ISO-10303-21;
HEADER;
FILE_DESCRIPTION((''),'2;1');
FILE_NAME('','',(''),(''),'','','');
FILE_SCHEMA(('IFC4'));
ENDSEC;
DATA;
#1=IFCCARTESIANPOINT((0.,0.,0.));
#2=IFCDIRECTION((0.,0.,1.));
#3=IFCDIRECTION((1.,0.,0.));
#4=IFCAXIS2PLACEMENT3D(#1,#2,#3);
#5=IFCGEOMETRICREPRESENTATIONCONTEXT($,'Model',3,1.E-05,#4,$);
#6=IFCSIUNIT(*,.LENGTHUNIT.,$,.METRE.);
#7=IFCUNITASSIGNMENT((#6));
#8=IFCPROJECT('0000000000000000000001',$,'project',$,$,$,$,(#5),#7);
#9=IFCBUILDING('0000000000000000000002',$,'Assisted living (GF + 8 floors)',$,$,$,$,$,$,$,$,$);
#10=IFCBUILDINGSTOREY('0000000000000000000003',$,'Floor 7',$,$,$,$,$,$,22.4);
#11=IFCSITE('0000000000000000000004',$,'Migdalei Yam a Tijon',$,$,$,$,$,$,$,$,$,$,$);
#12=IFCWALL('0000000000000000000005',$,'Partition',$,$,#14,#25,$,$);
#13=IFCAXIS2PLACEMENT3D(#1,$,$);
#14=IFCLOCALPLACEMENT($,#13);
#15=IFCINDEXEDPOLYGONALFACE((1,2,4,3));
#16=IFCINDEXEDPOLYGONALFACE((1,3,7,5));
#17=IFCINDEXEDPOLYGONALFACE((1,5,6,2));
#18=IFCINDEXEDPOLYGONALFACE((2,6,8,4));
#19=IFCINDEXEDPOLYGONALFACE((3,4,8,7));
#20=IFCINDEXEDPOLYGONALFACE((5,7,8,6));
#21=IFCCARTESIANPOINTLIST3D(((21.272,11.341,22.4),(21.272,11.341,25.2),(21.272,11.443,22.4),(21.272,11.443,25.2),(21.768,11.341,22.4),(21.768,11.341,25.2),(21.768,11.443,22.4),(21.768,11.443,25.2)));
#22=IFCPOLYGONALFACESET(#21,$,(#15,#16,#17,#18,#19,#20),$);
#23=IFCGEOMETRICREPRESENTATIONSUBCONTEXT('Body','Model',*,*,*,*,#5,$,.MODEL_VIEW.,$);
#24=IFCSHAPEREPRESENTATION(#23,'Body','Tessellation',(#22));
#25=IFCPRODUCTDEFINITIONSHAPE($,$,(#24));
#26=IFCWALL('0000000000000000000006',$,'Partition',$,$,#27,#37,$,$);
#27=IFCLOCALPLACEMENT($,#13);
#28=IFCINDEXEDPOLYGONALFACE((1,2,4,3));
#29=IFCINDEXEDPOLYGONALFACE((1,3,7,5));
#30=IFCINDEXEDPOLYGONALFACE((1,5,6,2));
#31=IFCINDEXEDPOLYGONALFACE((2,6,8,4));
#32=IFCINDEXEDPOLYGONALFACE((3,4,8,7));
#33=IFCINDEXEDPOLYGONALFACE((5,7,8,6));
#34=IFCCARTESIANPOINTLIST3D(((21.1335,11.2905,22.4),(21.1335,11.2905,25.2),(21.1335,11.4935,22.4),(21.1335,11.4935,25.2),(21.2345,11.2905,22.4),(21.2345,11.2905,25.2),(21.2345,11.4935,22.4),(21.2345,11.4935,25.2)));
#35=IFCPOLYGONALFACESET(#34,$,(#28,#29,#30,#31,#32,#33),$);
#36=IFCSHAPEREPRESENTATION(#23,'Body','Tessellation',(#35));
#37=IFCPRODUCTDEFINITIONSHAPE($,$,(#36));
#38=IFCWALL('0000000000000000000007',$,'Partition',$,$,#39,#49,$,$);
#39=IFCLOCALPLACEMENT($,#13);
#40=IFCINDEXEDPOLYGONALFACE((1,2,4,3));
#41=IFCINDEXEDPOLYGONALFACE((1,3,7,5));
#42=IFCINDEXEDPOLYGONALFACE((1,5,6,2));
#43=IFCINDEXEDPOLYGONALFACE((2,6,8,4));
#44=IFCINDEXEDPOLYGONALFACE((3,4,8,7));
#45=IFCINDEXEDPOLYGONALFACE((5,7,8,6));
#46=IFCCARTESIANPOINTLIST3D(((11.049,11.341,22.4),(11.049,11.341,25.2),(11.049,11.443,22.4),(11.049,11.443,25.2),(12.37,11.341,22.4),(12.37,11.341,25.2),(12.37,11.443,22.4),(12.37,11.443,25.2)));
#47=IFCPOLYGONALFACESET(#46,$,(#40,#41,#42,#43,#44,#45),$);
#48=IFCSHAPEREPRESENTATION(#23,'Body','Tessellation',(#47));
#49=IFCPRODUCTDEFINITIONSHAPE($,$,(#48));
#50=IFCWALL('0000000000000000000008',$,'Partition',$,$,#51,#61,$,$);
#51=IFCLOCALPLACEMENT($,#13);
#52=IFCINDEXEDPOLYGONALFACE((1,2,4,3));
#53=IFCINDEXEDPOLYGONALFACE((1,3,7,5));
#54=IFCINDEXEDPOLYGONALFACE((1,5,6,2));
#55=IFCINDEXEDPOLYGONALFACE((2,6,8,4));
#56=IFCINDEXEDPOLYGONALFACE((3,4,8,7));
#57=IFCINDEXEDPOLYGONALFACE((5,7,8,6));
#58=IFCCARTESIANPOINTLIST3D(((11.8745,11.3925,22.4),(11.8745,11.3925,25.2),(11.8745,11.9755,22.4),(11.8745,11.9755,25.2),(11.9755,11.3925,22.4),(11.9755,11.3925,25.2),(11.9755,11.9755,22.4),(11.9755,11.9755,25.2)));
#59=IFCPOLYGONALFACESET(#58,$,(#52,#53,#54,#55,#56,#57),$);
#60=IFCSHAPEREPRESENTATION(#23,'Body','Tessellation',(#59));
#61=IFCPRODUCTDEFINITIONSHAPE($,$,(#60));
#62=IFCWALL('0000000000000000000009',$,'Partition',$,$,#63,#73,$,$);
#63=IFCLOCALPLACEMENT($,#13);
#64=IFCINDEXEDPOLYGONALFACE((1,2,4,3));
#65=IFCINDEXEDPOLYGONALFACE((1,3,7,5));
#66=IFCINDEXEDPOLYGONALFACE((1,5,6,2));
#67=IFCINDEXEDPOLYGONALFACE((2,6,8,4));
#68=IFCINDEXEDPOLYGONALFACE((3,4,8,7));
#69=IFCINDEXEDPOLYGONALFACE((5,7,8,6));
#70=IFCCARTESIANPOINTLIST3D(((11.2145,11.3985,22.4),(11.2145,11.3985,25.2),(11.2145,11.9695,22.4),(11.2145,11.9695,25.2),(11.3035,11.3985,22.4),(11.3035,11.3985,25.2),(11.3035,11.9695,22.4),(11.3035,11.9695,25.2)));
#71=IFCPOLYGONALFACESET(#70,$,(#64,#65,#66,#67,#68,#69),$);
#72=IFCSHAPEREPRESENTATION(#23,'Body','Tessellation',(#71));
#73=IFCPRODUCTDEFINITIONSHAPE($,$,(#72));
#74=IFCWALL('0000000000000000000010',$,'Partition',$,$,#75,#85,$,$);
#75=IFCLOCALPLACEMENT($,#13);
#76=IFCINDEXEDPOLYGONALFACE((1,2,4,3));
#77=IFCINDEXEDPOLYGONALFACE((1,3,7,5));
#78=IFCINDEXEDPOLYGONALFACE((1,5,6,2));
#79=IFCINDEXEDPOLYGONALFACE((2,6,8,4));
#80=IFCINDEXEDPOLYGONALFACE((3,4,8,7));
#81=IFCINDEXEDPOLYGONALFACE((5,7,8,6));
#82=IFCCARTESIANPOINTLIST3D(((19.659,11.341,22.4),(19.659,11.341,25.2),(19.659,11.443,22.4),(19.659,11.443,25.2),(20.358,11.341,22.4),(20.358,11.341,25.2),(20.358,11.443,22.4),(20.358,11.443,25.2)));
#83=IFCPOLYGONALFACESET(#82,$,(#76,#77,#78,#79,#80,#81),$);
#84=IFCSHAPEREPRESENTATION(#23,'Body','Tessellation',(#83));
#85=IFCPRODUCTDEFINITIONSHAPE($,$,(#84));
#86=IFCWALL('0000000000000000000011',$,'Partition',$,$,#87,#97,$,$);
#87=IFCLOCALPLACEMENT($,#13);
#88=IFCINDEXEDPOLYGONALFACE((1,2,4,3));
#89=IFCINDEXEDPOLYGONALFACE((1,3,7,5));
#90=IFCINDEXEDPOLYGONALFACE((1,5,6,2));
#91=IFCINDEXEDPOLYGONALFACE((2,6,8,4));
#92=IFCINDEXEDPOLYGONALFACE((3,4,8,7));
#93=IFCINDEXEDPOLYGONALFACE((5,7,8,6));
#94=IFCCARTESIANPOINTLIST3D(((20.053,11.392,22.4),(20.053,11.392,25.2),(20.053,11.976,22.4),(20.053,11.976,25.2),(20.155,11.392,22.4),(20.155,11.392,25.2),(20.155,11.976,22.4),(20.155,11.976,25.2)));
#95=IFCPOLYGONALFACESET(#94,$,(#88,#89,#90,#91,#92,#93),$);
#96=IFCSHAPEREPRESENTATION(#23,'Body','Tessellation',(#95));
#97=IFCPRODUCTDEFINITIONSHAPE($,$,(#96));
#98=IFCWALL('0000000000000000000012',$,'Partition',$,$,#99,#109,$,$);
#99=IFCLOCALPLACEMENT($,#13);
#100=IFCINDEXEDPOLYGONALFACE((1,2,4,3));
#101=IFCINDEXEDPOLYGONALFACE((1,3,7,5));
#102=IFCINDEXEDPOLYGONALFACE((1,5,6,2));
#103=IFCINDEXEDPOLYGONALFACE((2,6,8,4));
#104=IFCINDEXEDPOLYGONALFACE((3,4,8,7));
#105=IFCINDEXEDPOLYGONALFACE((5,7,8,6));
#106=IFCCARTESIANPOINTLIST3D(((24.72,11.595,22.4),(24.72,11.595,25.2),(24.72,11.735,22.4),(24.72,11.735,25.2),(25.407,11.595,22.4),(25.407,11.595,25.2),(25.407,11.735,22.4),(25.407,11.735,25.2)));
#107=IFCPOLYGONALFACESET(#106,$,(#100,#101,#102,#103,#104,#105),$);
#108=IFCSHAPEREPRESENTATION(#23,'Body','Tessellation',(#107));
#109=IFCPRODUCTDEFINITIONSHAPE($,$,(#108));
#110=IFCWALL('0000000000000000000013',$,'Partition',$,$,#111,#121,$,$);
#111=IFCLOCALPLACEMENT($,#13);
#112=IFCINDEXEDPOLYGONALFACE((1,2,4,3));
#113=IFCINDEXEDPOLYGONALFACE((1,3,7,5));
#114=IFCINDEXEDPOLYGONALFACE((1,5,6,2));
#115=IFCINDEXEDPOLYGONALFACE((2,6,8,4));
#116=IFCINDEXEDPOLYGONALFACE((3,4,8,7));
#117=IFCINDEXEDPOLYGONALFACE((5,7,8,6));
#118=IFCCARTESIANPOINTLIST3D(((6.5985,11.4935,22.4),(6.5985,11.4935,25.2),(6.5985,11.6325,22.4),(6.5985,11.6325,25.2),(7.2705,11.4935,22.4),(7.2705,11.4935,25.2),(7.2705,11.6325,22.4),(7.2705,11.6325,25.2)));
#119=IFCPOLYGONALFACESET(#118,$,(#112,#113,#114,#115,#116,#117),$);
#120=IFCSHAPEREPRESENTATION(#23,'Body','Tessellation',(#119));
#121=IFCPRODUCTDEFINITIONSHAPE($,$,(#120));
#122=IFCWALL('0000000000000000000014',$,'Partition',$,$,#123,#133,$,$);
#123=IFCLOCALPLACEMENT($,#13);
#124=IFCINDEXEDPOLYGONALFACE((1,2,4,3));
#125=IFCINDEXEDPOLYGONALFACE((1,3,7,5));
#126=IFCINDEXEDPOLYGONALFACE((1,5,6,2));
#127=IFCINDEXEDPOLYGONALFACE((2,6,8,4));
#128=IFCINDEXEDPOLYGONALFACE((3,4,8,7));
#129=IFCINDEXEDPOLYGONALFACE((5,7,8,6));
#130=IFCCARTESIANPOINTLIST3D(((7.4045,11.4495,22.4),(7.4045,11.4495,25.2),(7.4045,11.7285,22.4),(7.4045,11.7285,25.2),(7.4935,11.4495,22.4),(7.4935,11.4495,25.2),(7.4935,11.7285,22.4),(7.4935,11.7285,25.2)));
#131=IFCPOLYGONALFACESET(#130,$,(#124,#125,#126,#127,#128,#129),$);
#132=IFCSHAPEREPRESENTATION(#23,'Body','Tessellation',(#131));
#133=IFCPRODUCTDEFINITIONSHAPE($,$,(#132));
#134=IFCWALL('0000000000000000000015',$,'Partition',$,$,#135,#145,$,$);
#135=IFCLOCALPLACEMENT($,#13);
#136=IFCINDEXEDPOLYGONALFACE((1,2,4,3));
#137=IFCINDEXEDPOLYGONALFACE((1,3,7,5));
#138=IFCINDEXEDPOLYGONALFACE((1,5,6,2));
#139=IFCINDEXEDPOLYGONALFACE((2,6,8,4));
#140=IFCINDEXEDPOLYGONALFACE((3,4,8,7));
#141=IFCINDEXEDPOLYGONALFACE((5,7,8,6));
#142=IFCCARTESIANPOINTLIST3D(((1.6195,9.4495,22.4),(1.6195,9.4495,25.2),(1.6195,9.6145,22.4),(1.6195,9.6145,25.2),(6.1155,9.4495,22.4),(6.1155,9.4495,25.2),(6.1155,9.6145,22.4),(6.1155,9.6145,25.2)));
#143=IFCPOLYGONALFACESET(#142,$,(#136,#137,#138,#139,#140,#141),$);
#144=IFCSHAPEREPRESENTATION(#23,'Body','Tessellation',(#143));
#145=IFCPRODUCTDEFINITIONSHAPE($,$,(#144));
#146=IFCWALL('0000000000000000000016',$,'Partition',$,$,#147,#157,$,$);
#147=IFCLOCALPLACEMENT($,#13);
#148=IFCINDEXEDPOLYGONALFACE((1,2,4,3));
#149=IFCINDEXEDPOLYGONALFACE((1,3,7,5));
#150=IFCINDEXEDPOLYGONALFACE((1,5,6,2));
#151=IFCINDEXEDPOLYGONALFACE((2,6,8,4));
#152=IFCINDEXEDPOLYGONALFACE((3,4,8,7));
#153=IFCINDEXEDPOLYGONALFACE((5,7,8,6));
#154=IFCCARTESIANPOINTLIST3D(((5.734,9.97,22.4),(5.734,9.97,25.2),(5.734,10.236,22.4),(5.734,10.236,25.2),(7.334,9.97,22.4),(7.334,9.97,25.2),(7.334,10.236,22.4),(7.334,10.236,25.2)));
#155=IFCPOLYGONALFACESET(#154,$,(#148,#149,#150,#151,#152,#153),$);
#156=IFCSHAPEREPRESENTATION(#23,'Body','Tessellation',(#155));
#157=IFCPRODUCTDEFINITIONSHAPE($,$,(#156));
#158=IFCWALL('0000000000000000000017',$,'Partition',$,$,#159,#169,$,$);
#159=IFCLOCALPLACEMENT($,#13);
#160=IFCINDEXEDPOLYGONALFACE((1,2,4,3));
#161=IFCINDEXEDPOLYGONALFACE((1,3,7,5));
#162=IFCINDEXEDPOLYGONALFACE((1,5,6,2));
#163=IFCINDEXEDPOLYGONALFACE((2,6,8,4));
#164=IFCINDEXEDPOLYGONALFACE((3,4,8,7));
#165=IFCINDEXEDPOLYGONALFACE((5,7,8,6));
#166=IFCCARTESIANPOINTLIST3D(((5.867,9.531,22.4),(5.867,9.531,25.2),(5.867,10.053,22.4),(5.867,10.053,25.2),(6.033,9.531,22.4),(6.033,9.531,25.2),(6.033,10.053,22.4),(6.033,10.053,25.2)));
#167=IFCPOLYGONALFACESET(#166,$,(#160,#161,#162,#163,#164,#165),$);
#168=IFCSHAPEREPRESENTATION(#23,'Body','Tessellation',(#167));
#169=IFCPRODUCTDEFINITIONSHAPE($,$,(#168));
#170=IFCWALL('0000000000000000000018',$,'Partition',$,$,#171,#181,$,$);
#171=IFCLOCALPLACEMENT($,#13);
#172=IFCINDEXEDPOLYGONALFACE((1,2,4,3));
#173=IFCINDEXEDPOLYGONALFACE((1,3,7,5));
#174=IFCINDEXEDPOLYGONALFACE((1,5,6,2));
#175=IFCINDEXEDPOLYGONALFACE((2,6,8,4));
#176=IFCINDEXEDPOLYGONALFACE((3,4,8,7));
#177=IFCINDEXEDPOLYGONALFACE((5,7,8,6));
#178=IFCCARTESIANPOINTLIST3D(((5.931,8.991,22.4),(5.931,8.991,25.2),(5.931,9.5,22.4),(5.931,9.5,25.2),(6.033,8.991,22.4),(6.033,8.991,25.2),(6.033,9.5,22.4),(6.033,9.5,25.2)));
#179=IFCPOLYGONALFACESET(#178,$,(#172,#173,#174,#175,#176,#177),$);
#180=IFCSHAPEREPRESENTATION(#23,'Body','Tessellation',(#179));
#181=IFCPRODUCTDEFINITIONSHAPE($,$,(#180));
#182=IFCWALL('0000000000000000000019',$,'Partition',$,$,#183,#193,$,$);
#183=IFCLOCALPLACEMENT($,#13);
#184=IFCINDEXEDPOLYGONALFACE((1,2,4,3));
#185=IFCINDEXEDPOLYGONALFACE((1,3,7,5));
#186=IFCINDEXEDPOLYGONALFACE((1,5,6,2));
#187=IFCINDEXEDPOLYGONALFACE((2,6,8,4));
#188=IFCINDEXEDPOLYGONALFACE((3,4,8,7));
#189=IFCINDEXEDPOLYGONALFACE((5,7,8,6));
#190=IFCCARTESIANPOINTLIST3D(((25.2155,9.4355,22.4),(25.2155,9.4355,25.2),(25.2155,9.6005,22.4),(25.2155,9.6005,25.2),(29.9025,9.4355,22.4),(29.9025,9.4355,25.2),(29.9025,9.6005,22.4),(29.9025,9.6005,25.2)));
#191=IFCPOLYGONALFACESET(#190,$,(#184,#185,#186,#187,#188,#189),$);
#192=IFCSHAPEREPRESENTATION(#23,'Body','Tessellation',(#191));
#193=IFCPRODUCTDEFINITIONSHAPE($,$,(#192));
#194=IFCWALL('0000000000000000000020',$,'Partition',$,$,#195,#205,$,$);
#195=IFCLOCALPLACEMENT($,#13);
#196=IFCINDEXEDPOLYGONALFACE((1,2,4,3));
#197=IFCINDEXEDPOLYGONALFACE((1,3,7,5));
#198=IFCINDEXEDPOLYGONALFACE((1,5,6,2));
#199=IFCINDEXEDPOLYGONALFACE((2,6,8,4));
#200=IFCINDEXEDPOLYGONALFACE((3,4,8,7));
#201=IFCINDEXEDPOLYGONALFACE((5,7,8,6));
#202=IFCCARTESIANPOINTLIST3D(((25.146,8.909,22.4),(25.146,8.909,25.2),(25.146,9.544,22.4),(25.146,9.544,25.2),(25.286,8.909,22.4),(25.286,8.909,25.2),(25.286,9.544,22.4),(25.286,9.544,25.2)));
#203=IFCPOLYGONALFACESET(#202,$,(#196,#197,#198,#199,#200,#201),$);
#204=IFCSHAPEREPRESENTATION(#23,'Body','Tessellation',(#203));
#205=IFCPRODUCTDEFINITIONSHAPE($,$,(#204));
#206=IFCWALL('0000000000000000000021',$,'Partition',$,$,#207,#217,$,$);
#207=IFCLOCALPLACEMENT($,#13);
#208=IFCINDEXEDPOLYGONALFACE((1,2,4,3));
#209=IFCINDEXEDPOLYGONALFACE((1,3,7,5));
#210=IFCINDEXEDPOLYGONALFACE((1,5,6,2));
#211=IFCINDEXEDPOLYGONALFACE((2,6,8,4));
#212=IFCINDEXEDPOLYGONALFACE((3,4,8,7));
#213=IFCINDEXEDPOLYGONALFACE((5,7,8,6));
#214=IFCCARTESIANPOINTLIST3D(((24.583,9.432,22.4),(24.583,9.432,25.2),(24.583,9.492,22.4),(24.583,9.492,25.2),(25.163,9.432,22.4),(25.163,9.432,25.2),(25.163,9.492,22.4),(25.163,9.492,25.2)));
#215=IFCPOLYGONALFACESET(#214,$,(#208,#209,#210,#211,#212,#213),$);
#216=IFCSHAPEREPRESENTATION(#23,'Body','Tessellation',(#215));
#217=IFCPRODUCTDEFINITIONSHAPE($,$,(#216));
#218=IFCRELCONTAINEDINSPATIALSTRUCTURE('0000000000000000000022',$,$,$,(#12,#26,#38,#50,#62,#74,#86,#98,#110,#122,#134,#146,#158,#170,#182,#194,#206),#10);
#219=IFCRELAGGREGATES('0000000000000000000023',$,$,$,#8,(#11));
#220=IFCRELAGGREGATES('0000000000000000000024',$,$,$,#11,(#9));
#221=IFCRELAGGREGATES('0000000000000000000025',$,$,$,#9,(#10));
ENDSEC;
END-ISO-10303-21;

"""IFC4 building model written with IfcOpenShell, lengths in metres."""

from ifc_helpers import new_model, si_unit, frame, origin_with_axes, context, subcontext, project, spatial, line, indexed_curve, outline, extrude, element, save


model = new_model("IFC4")

# Units and contexts
model_context = context("Model", 3, precision=1e-05, world=origin_with_axes())
body_context = subcontext(model_context, "Body", "Model", "MODEL_VIEW")
ifc_project = project(units=[si_unit("LENGTHUNIT", "METRE")], contexts=[model_context])

# Site, building, storey
site = spatial("IfcSite", under=ifc_project, Name="Migdalei Yam a Tijon")
building = spatial("IfcBuilding", under=site, Name="Assisted living (GF + 8 floors)")
storey = spatial("IfcBuildingStorey", under=building, Name="Floor 7", Elevation=22.4)

# Walls
element("IfcWall", 1, inside=storey, Name="Partition", context=body_context, shape_type="SweptSolid", body=[
    extrude(outline(indexed_curve([(0.0, 0.0), (0.496, 0.0), (0.496, 0.102), (0.0, 0.102)], segments=[line(1, 2, 3, 4, 1)])), frame((21.272, 11.341, 22.4), z_axis=(0.0, 0.0, 1.0), x_axis=(1.0, 0.0, 0.0)), (0.0, 0.0, 1.0), 2.8),
])
element("IfcWall", 2, inside=storey, Name="Partition", context=body_context, shape_type="SweptSolid", body=[
    extrude(outline(indexed_curve([(0.0, 0.0), (0.101, 0.0), (0.101, 0.203), (0.0, 0.203)], segments=[line(1, 2, 3, 4, 1)])), frame((21.1335, 11.2905, 22.4), z_axis=(0.0, 0.0, 1.0), x_axis=(1.0, 0.0, 0.0)), (0.0, 0.0, 1.0), 2.8),
])
element("IfcWall", 3, inside=storey, Name="Partition", context=body_context, shape_type="SweptSolid", body=[
    extrude(outline(indexed_curve([(0.0, 0.0), (1.321, 0.0), (1.321, 0.102), (0.0, 0.102)], segments=[line(1, 2, 3, 4, 1)])), frame((11.049, 11.341, 22.4), z_axis=(0.0, 0.0, 1.0), x_axis=(1.0, 0.0, 0.0)), (0.0, 0.0, 1.0), 2.8),
])
element("IfcWall", 4, inside=storey, Name="Partition", context=body_context, shape_type="SweptSolid", body=[
    extrude(outline(indexed_curve([(0.0, 0.0), (0.101, 0.0), (0.101, 0.583), (0.0, 0.583)], segments=[line(1, 2, 3, 4, 1)])), frame((11.8745, 11.3925, 22.4), z_axis=(0.0, 0.0, 1.0), x_axis=(1.0, 0.0, 0.0)), (0.0, 0.0, 1.0), 2.8),
])
element("IfcWall", 5, inside=storey, Name="Partition", context=body_context, shape_type="SweptSolid", body=[
    extrude(outline(indexed_curve([(0.0, 0.0), (0.089, 0.0), (0.089, 0.571), (0.0, 0.571)], segments=[line(1, 2, 3, 4, 1)])), frame((11.2145, 11.3985, 22.4), z_axis=(0.0, 0.0, 1.0), x_axis=(1.0, 0.0, 0.0)), (0.0, 0.0, 1.0), 2.8),
])
element("IfcWall", 6, inside=storey, Name="Partition", context=body_context, shape_type="SweptSolid", body=[
    extrude(outline(indexed_curve([(0.0, 0.0), (0.699, 0.0), (0.699, 0.102), (0.0, 0.102)], segments=[line(1, 2, 3, 4, 1)])), frame((19.659, 11.341, 22.4), z_axis=(0.0, 0.0, 1.0), x_axis=(1.0, 0.0, 0.0)), (0.0, 0.0, 1.0), 2.8),
])
element("IfcWall", 7, inside=storey, Name="Partition", context=body_context, shape_type="SweptSolid", body=[
    extrude(outline(indexed_curve([(0.0, 0.0), (0.102, 0.0), (0.102, 0.584), (0.0, 0.584)], segments=[line(1, 2, 3, 4, 1)])), frame((20.053, 11.392, 22.4), z_axis=(0.0, 0.0, 1.0), x_axis=(1.0, 0.0, 0.0)), (0.0, 0.0, 1.0), 2.8),
])
element("IfcWall", 8, inside=storey, Name="Partition", context=body_context, shape_type="SweptSolid", body=[
    extrude(outline(indexed_curve([(0.0, 0.0), (0.687, 0.0), (0.687, 0.14), (0.0, 0.14)], segments=[line(1, 2, 3, 4, 1)])), frame((24.72, 11.595, 22.4), z_axis=(0.0, 0.0, 1.0), x_axis=(1.0, 0.0, 0.0)), (0.0, 0.0, 1.0), 2.8),
])
element("IfcWall", 9, inside=storey, Name="Partition", context=body_context, shape_type="SweptSolid", body=[
    extrude(outline(indexed_curve([(0.0, 0.0), (0.672, 0.0), (0.672, 0.139), (0.0, 0.139)], segments=[line(1, 2, 3, 4, 1)])), frame((6.5985, 11.4935, 22.4), z_axis=(0.0, 0.0, 1.0), x_axis=(1.0, 0.0, 0.0)), (0.0, 0.0, 1.0), 2.8),
])
element("IfcWall", 10, inside=storey, Name="Partition", context=body_context, shape_type="SweptSolid", body=[
    extrude(outline(indexed_curve([(0.0, 0.0), (0.089, 0.0), (0.089, 0.279), (0.0, 0.279)], segments=[line(1, 2, 3, 4, 1)])), frame((7.4045, 11.4495, 22.4), z_axis=(0.0, 0.0, 1.0), x_axis=(1.0, 0.0, 0.0)), (0.0, 0.0, 1.0), 2.8),
])
element("IfcWall", 11, inside=storey, Name="Partition", context=body_context, shape_type="SweptSolid", body=[
    extrude(outline(indexed_curve([(0.0, 0.0), (4.496, 0.0), (4.496, 0.165), (0.0, 0.165)], segments=[line(1, 2, 3, 4, 1)])), frame((1.6195, 9.4495, 22.4), z_axis=(0.0, 0.0, 1.0), x_axis=(1.0, 0.0, 0.0)), (0.0, 0.0, 1.0), 2.8),
])
element("IfcWall", 12, inside=storey, Name="Partition", context=body_context, shape_type="SweptSolid", body=[
    extrude(outline(indexed_curve([(0.0, 0.0), (1.6, 0.0), (1.6, 0.266), (0.0, 0.266)], segments=[line(1, 2, 3, 4, 1)])), frame((5.734, 9.97, 22.4), z_axis=(0.0, 0.0, 1.0), x_axis=(1.0, 0.0, 0.0)), (0.0, 0.0, 1.0), 2.8),
])
element("IfcWall", 13, inside=storey, Name="Partition", context=body_context, shape_type="SweptSolid", body=[
    extrude(outline(indexed_curve([(0.0, 0.0), (0.166, 0.0), (0.166, 0.522), (0.0, 0.522)], segments=[line(1, 2, 3, 4, 1)])), frame((5.867, 9.531, 22.4), z_axis=(0.0, 0.0, 1.0), x_axis=(1.0, 0.0, 0.0)), (0.0, 0.0, 1.0), 2.8),
])
element("IfcWall", 14, inside=storey, Name="Partition", context=body_context, shape_type="SweptSolid", body=[
    extrude(outline(indexed_curve([(0.0, 0.0), (0.102, 0.0), (0.102, 0.509), (0.0, 0.509)], segments=[line(1, 2, 3, 4, 1)])), frame((5.931, 8.991, 22.4), z_axis=(0.0, 0.0, 1.0), x_axis=(1.0, 0.0, 0.0)), (0.0, 0.0, 1.0), 2.8),
])
element("IfcWall", 15, inside=storey, Name="Partition", context=body_context, shape_type="SweptSolid", body=[
    extrude(outline(indexed_curve([(0.0, 0.0), (4.687, 0.0), (4.687, 0.165), (0.0, 0.165)], segments=[line(1, 2, 3, 4, 1)])), frame((25.2155, 9.4355, 22.4), z_axis=(0.0, 0.0, 1.0), x_axis=(1.0, 0.0, 0.0)), (0.0, 0.0, 1.0), 2.8),
])
element("IfcWall", 16, inside=storey, Name="Partition", context=body_context, shape_type="SweptSolid", body=[
    extrude(outline(indexed_curve([(0.0, 0.0), (0.14, 0.0), (0.14, 0.635), (0.0, 0.635)], segments=[line(1, 2, 3, 4, 1)])), frame((25.146, 8.909, 22.4), z_axis=(0.0, 0.0, 1.0), x_axis=(1.0, 0.0, 0.0)), (0.0, 0.0, 1.0), 2.8),
])
element("IfcWall", 17, inside=storey, Name="Partition", context=body_context, shape_type="SweptSolid", body=[
    extrude(outline(indexed_curve([(0.0, 0.0), (0.58, 0.0), (0.58, 0.06), (0.0, 0.06)], segments=[line(1, 2, 3, 4, 1)])), frame((24.583, 9.432, 22.4), z_axis=(0.0, 0.0, 1.0), x_axis=(1.0, 0.0, 0.0)), (0.0, 0.0, 1.0), 2.8),
])

save(model, "model.ifc")
